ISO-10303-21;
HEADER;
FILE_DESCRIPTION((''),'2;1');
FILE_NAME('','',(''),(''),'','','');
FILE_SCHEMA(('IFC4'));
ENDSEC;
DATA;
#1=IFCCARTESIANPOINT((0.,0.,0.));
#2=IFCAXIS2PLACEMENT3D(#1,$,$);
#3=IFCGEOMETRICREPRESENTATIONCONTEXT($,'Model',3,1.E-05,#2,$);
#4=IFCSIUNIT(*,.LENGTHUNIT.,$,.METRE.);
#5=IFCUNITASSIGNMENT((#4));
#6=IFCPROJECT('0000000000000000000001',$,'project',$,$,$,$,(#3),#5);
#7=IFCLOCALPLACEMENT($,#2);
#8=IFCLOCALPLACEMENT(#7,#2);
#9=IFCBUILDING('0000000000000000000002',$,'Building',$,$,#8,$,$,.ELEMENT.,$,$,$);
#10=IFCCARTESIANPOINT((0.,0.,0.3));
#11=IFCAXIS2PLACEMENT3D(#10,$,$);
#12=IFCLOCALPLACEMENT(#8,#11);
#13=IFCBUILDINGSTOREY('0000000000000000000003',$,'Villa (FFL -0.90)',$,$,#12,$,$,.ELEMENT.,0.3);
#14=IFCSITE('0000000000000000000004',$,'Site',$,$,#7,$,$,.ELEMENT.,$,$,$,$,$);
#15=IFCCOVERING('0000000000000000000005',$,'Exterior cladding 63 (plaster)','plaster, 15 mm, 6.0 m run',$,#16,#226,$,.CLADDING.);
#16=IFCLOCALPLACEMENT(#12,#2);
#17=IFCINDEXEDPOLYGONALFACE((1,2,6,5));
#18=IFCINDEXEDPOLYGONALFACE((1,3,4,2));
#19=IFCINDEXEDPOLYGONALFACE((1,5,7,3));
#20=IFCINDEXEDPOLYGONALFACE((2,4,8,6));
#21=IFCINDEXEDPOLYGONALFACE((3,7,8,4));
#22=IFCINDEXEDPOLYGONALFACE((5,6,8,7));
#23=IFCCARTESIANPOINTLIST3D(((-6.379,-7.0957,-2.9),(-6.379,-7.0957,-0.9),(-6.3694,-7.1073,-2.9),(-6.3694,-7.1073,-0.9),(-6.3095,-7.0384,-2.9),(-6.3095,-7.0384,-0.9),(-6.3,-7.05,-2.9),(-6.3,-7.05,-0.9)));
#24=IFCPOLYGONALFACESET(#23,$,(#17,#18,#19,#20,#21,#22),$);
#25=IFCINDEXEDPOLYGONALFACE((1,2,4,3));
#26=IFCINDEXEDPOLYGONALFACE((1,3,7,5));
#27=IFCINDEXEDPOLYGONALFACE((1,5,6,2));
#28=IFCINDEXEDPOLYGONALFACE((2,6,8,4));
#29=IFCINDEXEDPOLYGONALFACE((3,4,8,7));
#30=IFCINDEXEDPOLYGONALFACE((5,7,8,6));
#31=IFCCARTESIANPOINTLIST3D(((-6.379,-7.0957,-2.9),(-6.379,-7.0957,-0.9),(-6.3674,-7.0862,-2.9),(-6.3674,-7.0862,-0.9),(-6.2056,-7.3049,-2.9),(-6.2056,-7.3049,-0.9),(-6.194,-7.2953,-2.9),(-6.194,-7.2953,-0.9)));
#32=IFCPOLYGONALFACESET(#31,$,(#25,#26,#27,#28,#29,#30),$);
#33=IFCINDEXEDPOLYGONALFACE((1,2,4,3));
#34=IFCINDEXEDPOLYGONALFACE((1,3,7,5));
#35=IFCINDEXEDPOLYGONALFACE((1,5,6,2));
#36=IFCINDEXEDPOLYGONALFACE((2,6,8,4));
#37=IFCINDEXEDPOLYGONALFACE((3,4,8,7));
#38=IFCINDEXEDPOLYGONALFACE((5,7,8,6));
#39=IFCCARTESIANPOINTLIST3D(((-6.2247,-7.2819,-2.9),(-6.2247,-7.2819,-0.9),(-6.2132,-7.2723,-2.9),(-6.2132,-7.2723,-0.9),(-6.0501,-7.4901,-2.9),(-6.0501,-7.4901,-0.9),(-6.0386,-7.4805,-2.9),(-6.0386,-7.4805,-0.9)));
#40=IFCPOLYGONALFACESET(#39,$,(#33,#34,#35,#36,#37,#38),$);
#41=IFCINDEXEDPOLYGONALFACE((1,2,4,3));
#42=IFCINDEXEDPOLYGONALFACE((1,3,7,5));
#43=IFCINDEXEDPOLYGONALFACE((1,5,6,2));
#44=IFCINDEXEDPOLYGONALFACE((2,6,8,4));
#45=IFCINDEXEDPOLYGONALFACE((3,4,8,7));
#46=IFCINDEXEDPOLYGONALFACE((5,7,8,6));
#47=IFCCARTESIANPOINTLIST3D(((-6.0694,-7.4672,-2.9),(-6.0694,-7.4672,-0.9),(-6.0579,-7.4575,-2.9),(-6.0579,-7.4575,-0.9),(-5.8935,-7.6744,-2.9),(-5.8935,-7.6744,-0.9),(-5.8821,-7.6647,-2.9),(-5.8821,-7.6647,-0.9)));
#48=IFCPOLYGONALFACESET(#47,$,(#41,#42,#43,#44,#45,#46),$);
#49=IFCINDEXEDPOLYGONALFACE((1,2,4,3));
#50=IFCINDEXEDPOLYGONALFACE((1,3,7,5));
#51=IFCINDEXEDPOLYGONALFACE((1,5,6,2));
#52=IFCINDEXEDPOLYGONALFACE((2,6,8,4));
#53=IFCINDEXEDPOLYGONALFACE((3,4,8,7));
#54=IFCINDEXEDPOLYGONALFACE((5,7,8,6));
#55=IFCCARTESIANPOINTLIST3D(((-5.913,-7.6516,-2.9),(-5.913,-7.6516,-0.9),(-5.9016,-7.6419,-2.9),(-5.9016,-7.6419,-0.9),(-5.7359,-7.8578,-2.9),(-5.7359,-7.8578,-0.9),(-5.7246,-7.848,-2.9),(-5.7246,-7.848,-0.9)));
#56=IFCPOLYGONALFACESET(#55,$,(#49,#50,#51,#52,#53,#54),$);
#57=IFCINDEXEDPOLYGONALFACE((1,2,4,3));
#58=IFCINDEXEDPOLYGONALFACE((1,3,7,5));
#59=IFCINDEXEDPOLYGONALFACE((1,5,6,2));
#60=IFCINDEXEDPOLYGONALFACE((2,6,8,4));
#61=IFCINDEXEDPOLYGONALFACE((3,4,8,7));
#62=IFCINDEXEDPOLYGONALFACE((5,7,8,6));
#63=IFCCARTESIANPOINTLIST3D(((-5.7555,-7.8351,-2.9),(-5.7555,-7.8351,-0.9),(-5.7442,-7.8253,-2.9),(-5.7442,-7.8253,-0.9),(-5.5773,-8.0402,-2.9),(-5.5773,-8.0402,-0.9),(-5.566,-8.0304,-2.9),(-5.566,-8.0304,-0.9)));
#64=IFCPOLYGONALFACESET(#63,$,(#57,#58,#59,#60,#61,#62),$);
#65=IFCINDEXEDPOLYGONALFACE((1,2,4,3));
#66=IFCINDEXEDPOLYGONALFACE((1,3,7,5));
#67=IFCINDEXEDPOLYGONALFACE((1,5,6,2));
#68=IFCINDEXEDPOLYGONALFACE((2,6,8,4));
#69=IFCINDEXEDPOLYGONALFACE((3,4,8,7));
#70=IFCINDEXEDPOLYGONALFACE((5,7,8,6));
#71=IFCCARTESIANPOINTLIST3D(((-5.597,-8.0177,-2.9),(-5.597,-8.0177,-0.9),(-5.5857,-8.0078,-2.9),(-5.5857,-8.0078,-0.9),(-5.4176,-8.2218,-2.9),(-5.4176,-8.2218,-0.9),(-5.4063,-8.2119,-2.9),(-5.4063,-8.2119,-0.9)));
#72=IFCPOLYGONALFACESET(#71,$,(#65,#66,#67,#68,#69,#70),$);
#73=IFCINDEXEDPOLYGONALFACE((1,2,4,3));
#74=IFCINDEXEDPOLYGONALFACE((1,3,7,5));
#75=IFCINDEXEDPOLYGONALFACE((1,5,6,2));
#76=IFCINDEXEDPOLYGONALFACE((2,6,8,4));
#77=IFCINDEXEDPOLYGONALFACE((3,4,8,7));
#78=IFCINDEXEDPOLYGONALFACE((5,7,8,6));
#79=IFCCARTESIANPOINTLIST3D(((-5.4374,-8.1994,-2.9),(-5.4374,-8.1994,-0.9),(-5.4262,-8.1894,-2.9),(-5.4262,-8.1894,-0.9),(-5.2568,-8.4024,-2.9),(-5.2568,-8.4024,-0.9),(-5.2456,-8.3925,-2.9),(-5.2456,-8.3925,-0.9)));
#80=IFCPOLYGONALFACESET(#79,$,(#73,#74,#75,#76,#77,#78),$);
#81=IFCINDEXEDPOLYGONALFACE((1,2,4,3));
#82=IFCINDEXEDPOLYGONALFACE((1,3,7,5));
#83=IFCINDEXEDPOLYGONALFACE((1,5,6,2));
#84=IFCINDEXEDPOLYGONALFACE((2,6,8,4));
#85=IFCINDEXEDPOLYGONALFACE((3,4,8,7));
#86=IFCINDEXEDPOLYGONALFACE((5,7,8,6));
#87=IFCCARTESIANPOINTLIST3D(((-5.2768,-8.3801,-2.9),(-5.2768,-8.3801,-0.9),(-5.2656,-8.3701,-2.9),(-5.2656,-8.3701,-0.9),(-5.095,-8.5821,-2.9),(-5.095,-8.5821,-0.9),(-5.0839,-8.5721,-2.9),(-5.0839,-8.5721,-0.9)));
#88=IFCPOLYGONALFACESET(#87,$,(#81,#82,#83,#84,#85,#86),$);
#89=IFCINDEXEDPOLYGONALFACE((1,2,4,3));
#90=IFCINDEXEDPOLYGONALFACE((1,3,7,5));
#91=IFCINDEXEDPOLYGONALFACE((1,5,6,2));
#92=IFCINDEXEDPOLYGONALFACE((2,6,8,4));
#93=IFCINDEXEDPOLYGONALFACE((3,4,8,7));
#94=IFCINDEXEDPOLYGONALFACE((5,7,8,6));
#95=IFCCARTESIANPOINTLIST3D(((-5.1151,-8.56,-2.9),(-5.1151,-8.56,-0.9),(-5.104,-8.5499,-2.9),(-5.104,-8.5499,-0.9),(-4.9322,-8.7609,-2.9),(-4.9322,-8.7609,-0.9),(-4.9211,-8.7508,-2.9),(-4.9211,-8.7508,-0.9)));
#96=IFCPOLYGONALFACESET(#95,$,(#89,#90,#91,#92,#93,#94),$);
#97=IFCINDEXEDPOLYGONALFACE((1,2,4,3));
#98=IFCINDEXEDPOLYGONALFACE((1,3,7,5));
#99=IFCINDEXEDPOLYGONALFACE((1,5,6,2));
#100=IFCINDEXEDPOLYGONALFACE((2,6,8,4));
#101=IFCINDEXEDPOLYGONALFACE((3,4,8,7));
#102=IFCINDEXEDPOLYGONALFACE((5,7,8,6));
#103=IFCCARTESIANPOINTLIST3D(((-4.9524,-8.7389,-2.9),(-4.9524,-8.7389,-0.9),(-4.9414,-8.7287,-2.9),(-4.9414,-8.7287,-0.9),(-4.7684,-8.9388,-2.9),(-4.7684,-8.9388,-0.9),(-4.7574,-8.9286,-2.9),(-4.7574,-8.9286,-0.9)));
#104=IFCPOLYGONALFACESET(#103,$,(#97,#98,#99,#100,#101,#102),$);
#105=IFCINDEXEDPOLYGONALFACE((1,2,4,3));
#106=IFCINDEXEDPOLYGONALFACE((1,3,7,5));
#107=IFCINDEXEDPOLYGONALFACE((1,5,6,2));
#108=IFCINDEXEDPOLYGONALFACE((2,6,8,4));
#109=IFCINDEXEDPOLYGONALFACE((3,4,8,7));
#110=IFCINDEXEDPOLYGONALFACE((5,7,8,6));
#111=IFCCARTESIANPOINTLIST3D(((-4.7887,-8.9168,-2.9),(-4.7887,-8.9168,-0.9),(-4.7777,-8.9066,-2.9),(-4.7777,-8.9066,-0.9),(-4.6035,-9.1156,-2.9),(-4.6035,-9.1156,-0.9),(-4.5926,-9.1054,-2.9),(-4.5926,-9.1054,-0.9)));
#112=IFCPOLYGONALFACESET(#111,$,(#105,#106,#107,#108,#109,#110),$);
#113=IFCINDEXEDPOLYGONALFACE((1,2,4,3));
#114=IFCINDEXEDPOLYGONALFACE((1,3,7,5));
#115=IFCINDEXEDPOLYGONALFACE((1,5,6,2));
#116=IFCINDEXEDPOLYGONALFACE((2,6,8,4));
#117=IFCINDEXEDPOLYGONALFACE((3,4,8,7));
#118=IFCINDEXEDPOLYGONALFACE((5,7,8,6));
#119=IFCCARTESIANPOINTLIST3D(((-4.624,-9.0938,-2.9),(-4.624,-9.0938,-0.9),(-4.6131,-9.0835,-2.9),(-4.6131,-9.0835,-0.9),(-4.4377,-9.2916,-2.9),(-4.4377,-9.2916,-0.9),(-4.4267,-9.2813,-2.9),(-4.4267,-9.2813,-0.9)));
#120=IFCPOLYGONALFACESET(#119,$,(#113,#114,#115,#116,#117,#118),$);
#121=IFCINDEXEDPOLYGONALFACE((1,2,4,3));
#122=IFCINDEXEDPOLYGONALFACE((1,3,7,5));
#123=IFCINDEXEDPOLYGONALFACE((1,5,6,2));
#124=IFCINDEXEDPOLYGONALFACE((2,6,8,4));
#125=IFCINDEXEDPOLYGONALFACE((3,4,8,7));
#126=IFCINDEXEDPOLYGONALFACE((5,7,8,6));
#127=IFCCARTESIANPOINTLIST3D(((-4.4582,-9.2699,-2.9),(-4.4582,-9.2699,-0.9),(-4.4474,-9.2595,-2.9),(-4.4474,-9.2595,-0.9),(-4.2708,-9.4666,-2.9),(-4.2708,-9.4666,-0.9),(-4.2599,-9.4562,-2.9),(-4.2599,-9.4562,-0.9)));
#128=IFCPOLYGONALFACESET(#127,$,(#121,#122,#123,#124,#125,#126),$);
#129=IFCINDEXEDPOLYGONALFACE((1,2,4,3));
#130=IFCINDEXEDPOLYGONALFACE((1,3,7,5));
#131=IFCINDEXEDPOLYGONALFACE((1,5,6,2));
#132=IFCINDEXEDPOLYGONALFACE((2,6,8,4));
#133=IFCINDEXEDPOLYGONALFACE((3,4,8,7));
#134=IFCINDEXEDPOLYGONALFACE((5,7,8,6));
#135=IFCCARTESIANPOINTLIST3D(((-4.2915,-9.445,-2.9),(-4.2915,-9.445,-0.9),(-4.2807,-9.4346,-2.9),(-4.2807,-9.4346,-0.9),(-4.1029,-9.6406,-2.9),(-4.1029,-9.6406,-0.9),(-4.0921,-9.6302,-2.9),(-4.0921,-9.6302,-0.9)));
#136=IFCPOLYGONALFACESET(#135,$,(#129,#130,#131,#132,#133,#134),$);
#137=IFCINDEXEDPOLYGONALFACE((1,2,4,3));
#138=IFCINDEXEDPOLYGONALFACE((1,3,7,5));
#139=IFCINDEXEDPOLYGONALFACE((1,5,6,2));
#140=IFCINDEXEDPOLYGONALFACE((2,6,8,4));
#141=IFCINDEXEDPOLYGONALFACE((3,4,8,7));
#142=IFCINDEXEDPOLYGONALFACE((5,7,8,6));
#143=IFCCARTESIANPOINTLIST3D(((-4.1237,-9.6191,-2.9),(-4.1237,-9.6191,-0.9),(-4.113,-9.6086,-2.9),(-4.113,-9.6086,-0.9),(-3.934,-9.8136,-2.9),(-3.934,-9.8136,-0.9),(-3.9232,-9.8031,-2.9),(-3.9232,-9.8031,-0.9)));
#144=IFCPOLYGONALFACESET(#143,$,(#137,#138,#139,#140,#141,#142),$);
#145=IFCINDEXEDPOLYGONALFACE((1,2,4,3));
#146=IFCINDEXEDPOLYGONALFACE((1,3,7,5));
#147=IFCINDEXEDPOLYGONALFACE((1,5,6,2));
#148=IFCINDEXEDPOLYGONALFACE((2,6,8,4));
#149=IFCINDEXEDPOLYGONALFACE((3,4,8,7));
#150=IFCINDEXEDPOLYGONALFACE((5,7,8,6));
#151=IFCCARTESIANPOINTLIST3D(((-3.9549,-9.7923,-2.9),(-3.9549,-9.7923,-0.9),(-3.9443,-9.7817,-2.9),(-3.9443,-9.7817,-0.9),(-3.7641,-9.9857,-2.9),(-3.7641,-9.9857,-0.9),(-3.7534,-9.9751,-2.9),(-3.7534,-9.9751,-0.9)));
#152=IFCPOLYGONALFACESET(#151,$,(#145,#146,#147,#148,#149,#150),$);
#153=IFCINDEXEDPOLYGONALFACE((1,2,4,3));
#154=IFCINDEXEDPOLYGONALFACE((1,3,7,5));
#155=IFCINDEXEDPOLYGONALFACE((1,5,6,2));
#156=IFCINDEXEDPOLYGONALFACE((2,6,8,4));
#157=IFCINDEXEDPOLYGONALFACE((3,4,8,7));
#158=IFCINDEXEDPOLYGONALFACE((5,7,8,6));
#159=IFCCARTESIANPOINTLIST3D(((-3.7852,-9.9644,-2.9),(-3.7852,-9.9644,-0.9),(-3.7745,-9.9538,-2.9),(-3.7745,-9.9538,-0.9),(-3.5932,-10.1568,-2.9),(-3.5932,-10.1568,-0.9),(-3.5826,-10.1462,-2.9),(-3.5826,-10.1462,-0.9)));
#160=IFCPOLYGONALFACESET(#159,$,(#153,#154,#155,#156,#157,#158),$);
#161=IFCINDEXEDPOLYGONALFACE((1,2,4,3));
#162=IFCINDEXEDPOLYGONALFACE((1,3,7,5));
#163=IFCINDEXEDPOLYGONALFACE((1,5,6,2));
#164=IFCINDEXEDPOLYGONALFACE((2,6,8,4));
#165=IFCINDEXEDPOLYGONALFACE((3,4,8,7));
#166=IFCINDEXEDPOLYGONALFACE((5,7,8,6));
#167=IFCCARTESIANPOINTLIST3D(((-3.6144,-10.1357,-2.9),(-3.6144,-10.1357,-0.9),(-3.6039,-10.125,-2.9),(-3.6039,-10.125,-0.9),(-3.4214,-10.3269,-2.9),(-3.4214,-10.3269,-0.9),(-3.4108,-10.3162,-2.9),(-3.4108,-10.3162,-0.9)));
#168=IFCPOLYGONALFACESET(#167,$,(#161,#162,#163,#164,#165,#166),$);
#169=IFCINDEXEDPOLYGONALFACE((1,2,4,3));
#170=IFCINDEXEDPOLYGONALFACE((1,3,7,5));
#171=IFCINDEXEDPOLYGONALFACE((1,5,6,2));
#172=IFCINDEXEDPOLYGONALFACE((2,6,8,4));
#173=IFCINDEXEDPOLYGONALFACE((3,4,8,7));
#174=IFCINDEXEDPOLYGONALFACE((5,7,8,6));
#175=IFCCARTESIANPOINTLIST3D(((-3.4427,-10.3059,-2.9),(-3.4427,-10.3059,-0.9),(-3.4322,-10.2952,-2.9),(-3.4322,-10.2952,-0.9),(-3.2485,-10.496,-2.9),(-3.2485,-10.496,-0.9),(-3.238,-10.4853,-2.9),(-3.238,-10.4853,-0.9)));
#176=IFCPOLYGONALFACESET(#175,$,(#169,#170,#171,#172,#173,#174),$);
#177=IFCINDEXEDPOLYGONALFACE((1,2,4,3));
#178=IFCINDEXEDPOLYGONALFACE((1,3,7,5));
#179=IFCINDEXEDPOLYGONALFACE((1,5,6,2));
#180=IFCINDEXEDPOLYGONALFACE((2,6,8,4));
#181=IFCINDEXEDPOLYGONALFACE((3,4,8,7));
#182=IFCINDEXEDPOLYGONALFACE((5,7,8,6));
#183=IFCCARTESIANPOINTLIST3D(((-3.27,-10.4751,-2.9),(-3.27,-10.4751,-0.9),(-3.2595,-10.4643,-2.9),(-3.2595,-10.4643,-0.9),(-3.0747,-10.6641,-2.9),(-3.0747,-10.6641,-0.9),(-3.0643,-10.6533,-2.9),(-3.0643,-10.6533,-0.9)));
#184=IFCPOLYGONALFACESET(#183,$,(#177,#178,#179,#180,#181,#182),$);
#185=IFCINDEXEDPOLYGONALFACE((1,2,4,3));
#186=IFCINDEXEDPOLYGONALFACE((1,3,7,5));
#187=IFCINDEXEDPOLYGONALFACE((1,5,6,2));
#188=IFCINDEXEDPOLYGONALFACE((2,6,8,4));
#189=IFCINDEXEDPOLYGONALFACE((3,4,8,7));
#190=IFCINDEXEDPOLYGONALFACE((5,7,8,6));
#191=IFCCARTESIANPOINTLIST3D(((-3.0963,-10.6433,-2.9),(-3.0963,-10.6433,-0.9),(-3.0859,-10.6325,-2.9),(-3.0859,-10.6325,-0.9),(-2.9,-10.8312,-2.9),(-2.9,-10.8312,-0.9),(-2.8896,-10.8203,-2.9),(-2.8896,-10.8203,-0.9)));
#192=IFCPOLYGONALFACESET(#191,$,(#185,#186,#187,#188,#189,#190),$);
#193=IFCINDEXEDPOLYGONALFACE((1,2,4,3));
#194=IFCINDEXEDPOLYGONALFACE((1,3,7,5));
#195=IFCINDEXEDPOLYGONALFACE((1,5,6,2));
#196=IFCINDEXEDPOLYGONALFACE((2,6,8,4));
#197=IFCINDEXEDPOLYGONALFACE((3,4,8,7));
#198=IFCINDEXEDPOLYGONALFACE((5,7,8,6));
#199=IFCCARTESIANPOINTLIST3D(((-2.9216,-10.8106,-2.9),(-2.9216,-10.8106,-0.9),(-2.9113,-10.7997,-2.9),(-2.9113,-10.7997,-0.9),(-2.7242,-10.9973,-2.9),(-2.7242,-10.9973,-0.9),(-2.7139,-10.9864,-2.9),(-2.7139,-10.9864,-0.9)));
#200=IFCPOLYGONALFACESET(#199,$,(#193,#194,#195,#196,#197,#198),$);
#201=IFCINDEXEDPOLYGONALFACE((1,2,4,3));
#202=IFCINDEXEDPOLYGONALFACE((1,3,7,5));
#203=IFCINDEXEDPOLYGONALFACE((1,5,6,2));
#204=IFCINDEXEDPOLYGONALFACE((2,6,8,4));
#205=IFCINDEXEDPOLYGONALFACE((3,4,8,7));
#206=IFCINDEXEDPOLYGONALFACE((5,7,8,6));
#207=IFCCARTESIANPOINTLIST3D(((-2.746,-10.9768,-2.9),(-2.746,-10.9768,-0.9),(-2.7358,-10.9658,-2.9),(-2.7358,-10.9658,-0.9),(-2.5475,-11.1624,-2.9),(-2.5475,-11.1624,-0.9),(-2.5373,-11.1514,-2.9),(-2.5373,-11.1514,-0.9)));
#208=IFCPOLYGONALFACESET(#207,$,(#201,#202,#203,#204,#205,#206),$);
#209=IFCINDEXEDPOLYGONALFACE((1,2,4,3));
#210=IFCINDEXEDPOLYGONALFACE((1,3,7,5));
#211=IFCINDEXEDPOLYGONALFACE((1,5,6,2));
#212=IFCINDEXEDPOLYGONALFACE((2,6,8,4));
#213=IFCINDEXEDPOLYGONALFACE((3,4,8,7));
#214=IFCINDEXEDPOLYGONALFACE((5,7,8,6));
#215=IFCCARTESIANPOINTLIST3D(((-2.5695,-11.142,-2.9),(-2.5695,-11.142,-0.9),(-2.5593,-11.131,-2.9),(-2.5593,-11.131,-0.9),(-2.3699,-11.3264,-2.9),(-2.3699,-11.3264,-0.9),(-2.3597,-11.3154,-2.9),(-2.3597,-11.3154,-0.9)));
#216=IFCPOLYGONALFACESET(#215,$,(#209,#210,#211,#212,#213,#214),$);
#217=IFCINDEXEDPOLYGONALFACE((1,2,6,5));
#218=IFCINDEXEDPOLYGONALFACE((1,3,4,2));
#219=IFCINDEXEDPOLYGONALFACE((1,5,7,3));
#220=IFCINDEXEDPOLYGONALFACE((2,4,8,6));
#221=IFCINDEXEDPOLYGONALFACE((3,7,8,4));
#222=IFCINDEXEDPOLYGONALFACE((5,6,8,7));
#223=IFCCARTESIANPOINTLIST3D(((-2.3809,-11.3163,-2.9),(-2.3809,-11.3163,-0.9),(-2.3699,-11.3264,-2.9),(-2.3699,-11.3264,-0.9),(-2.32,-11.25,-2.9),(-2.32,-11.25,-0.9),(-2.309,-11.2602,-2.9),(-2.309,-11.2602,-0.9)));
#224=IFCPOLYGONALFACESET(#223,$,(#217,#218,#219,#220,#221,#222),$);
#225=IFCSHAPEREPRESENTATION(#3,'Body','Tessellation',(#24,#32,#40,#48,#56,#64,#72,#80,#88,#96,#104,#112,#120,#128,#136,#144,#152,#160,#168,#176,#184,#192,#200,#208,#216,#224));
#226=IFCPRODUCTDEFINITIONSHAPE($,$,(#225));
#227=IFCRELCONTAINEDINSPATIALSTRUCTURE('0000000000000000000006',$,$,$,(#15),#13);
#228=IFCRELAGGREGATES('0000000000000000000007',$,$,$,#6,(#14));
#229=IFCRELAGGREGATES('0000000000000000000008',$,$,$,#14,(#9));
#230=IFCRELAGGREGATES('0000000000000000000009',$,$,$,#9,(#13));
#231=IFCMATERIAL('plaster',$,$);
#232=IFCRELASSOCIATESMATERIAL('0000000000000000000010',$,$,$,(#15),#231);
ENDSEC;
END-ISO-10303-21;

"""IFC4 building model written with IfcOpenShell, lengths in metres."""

from ifc_helpers import new_model, si_unit, frame, origin, origin_with_axes, place, context, project, spatial, polyline, outline, extrude, material, element, save


model = new_model("IFC4")

# Units and contexts
model_context = context("Model", 3, precision=1e-05, world=origin())
ifc_project = project(units=[si_unit("LENGTHUNIT", "METRE")], contexts=[model_context])

# Site, building, storey
site_placement = place(None, origin())
site = spatial("IfcSite", under=ifc_project, at=site_placement, Name="Site", CompositionType="ELEMENT")
building_placement = place(site_placement, origin())
building = spatial("IfcBuilding", under=site, at=building_placement, Name="Building", CompositionType="ELEMENT")
storey_placement = place(building_placement, frame((0.0, 0.0, 0.3)))
storey = spatial("IfcBuildingStorey", under=building, at=storey_placement, Name="Villa (FFL -0.90)", CompositionType="ELEMENT", Elevation=0.3)

# Covering
ifc_material = material(Name="plaster")
covering_1_placement = place(storey_placement, origin_with_axes())
element("IfcCovering", 1, at=covering_1_placement, inside=storey, material=ifc_material, Name="Exterior cladding 63 (plaster)", Description="plaster, 15 mm, 6.0 m run", PredefinedType="CLADDING", context=model_context, shape_type="SweptSolid", body=[
    extrude(outline(polyline([(-6.3095, -7.0384), (-6.379, -7.0957), (-6.3694, -7.1073), (-6.3, -7.05), (-6.3095, -7.0384)])), frame((0.0, 0.0, -2.9)), (0.0, 0.0, 1.0), 2.0),
    extrude(outline(polyline([(-6.379, -7.0957), (-6.2056, -7.3049), (-6.194, -7.2953), (-6.3674, -7.0862), (-6.379, -7.0957)])), frame((0.0, 0.0, -2.9)), (0.0, 0.0, 1.0), 2.0),
    extrude(outline(polyline([(-6.2247, -7.2819), (-6.0501, -7.4901), (-6.0386, -7.4805), (-6.2132, -7.2723), (-6.2247, -7.2819)])), frame((0.0, 0.0, -2.9)), (0.0, 0.0, 1.0), 2.0),
    extrude(outline(polyline([(-6.0694, -7.4672), (-5.8935, -7.6744), (-5.8821, -7.6647), (-6.0579, -7.4575), (-6.0694, -7.4672)])), frame((0.0, 0.0, -2.9)), (0.0, 0.0, 1.0), 2.0),
    extrude(outline(polyline([(-5.913, -7.6516), (-5.7359, -7.8578), (-5.7246, -7.848), (-5.9016, -7.6419), (-5.913, -7.6516)])), frame((0.0, 0.0, -2.9)), (0.0, 0.0, 1.0), 2.0),
    extrude(outline(polyline([(-5.7555, -7.8351), (-5.5773, -8.0402), (-5.566, -8.0304), (-5.7442, -7.8253), (-5.7555, -7.8351)])), frame((0.0, 0.0, -2.9)), (0.0, 0.0, 1.0), 2.0),
    extrude(outline(polyline([(-5.597, -8.0177), (-5.4176, -8.2218), (-5.4063, -8.2119), (-5.5857, -8.0078), (-5.597, -8.0177)])), frame((0.0, 0.0, -2.9)), (0.0, 0.0, 1.0), 2.0),
    extrude(outline(polyline([(-5.4374, -8.1994), (-5.2568, -8.4024), (-5.2456, -8.3925), (-5.4262, -8.1894), (-5.4374, -8.1994)])), frame((0.0, 0.0, -2.9)), (0.0, 0.0, 1.0), 2.0),
    extrude(outline(polyline([(-5.2768, -8.3801), (-5.095, -8.5821), (-5.0839, -8.5721), (-5.2656, -8.3701), (-5.2768, -8.3801)])), frame((0.0, 0.0, -2.9)), (0.0, 0.0, 1.0), 2.0),
    extrude(outline(polyline([(-5.1151, -8.56), (-4.9322, -8.7609), (-4.9211, -8.7508), (-5.104, -8.5499), (-5.1151, -8.56)])), frame((0.0, 0.0, -2.9)), (0.0, 0.0, 1.0), 2.0),
    extrude(outline(polyline([(-4.9524, -8.7389), (-4.7684, -8.9388), (-4.7574, -8.9286), (-4.9414, -8.7287), (-4.9524, -8.7389)])), frame((0.0, 0.0, -2.9)), (0.0, 0.0, 1.0), 2.0),
    extrude(outline(polyline([(-4.7887, -8.9168), (-4.6035, -9.1156), (-4.5926, -9.1054), (-4.7777, -8.9066), (-4.7887, -8.9168)])), frame((0.0, 0.0, -2.9)), (0.0, 0.0, 1.0), 2.0),
    extrude(outline(polyline([(-4.624, -9.0938), (-4.4377, -9.2916), (-4.4267, -9.2813), (-4.6131, -9.0835), (-4.624, -9.0938)])), frame((0.0, 0.0, -2.9)), (0.0, 0.0, 1.0), 2.0),
    extrude(outline(polyline([(-4.4582, -9.2699), (-4.2708, -9.4666), (-4.2599, -9.4562), (-4.4474, -9.2595), (-4.4582, -9.2699)])), frame((0.0, 0.0, -2.9)), (0.0, 0.0, 1.0), 2.0),
    extrude(outline(polyline([(-4.2915, -9.445), (-4.1029, -9.6406), (-4.0921, -9.6302), (-4.2807, -9.4346), (-4.2915, -9.445)])), frame((0.0, 0.0, -2.9)), (0.0, 0.0, 1.0), 2.0),
    extrude(outline(polyline([(-4.1237, -9.6191), (-3.934, -9.8136), (-3.9232, -9.8031), (-4.113, -9.6086), (-4.1237, -9.6191)])), frame((0.0, 0.0, -2.9)), (0.0, 0.0, 1.0), 2.0),
    extrude(outline(polyline([(-3.9549, -9.7923), (-3.7641, -9.9857), (-3.7534, -9.9751), (-3.9443, -9.7817), (-3.9549, -9.7923)])), frame((0.0, 0.0, -2.9)), (0.0, 0.0, 1.0), 2.0),
    extrude(outline(polyline([(-3.7852, -9.9644), (-3.5932, -10.1568), (-3.5826, -10.1462), (-3.7745, -9.9538), (-3.7852, -9.9644)])), frame((0.0, 0.0, -2.9)), (0.0, 0.0, 1.0), 2.0),
    extrude(outline(polyline([(-3.6144, -10.1357), (-3.4214, -10.3269), (-3.4108, -10.3162), (-3.6039, -10.125), (-3.6144, -10.1357)])), frame((0.0, 0.0, -2.9)), (0.0, 0.0, 1.0), 2.0),
    extrude(outline(polyline([(-3.4427, -10.3059), (-3.2485, -10.496), (-3.238, -10.4853), (-3.4322, -10.2952), (-3.4427, -10.3059)])), frame((0.0, 0.0, -2.9)), (0.0, 0.0, 1.0), 2.0),
    extrude(outline(polyline([(-3.27, -10.4751), (-3.0747, -10.6641), (-3.0643, -10.6533), (-3.2595, -10.4643), (-3.27, -10.4751)])), frame((0.0, 0.0, -2.9)), (0.0, 0.0, 1.0), 2.0),
    extrude(outline(polyline([(-3.0963, -10.6433), (-2.9, -10.8312), (-2.8896, -10.8203), (-3.0859, -10.6325), (-3.0963, -10.6433)])), frame((0.0, 0.0, -2.9)), (0.0, 0.0, 1.0), 2.0),
    extrude(outline(polyline([(-2.9216, -10.8106), (-2.7242, -10.9973), (-2.7139, -10.9864), (-2.9113, -10.7997), (-2.9216, -10.8106)])), frame((0.0, 0.0, -2.9)), (0.0, 0.0, 1.0), 2.0),
    extrude(outline(polyline([(-2.746, -10.9768), (-2.5475, -11.1624), (-2.5373, -11.1514), (-2.7358, -10.9658), (-2.746, -10.9768)])), frame((0.0, 0.0, -2.9)), (0.0, 0.0, 1.0), 2.0),
    extrude(outline(polyline([(-2.5695, -11.142), (-2.3699, -11.3264), (-2.3597, -11.3154), (-2.5593, -11.131), (-2.5695, -11.142)])), frame((0.0, 0.0, -2.9)), (0.0, 0.0, 1.0), 2.0),
    extrude(outline(polyline([(-2.3699, -11.3264), (-2.309, -11.2601), (-2.32, -11.25), (-2.3809, -11.3163), (-2.3699, -11.3264)])), frame((0.0, 0.0, -2.9)), (0.0, 0.0, 1.0), 2.0),
])

save(model, "model.ifc")
